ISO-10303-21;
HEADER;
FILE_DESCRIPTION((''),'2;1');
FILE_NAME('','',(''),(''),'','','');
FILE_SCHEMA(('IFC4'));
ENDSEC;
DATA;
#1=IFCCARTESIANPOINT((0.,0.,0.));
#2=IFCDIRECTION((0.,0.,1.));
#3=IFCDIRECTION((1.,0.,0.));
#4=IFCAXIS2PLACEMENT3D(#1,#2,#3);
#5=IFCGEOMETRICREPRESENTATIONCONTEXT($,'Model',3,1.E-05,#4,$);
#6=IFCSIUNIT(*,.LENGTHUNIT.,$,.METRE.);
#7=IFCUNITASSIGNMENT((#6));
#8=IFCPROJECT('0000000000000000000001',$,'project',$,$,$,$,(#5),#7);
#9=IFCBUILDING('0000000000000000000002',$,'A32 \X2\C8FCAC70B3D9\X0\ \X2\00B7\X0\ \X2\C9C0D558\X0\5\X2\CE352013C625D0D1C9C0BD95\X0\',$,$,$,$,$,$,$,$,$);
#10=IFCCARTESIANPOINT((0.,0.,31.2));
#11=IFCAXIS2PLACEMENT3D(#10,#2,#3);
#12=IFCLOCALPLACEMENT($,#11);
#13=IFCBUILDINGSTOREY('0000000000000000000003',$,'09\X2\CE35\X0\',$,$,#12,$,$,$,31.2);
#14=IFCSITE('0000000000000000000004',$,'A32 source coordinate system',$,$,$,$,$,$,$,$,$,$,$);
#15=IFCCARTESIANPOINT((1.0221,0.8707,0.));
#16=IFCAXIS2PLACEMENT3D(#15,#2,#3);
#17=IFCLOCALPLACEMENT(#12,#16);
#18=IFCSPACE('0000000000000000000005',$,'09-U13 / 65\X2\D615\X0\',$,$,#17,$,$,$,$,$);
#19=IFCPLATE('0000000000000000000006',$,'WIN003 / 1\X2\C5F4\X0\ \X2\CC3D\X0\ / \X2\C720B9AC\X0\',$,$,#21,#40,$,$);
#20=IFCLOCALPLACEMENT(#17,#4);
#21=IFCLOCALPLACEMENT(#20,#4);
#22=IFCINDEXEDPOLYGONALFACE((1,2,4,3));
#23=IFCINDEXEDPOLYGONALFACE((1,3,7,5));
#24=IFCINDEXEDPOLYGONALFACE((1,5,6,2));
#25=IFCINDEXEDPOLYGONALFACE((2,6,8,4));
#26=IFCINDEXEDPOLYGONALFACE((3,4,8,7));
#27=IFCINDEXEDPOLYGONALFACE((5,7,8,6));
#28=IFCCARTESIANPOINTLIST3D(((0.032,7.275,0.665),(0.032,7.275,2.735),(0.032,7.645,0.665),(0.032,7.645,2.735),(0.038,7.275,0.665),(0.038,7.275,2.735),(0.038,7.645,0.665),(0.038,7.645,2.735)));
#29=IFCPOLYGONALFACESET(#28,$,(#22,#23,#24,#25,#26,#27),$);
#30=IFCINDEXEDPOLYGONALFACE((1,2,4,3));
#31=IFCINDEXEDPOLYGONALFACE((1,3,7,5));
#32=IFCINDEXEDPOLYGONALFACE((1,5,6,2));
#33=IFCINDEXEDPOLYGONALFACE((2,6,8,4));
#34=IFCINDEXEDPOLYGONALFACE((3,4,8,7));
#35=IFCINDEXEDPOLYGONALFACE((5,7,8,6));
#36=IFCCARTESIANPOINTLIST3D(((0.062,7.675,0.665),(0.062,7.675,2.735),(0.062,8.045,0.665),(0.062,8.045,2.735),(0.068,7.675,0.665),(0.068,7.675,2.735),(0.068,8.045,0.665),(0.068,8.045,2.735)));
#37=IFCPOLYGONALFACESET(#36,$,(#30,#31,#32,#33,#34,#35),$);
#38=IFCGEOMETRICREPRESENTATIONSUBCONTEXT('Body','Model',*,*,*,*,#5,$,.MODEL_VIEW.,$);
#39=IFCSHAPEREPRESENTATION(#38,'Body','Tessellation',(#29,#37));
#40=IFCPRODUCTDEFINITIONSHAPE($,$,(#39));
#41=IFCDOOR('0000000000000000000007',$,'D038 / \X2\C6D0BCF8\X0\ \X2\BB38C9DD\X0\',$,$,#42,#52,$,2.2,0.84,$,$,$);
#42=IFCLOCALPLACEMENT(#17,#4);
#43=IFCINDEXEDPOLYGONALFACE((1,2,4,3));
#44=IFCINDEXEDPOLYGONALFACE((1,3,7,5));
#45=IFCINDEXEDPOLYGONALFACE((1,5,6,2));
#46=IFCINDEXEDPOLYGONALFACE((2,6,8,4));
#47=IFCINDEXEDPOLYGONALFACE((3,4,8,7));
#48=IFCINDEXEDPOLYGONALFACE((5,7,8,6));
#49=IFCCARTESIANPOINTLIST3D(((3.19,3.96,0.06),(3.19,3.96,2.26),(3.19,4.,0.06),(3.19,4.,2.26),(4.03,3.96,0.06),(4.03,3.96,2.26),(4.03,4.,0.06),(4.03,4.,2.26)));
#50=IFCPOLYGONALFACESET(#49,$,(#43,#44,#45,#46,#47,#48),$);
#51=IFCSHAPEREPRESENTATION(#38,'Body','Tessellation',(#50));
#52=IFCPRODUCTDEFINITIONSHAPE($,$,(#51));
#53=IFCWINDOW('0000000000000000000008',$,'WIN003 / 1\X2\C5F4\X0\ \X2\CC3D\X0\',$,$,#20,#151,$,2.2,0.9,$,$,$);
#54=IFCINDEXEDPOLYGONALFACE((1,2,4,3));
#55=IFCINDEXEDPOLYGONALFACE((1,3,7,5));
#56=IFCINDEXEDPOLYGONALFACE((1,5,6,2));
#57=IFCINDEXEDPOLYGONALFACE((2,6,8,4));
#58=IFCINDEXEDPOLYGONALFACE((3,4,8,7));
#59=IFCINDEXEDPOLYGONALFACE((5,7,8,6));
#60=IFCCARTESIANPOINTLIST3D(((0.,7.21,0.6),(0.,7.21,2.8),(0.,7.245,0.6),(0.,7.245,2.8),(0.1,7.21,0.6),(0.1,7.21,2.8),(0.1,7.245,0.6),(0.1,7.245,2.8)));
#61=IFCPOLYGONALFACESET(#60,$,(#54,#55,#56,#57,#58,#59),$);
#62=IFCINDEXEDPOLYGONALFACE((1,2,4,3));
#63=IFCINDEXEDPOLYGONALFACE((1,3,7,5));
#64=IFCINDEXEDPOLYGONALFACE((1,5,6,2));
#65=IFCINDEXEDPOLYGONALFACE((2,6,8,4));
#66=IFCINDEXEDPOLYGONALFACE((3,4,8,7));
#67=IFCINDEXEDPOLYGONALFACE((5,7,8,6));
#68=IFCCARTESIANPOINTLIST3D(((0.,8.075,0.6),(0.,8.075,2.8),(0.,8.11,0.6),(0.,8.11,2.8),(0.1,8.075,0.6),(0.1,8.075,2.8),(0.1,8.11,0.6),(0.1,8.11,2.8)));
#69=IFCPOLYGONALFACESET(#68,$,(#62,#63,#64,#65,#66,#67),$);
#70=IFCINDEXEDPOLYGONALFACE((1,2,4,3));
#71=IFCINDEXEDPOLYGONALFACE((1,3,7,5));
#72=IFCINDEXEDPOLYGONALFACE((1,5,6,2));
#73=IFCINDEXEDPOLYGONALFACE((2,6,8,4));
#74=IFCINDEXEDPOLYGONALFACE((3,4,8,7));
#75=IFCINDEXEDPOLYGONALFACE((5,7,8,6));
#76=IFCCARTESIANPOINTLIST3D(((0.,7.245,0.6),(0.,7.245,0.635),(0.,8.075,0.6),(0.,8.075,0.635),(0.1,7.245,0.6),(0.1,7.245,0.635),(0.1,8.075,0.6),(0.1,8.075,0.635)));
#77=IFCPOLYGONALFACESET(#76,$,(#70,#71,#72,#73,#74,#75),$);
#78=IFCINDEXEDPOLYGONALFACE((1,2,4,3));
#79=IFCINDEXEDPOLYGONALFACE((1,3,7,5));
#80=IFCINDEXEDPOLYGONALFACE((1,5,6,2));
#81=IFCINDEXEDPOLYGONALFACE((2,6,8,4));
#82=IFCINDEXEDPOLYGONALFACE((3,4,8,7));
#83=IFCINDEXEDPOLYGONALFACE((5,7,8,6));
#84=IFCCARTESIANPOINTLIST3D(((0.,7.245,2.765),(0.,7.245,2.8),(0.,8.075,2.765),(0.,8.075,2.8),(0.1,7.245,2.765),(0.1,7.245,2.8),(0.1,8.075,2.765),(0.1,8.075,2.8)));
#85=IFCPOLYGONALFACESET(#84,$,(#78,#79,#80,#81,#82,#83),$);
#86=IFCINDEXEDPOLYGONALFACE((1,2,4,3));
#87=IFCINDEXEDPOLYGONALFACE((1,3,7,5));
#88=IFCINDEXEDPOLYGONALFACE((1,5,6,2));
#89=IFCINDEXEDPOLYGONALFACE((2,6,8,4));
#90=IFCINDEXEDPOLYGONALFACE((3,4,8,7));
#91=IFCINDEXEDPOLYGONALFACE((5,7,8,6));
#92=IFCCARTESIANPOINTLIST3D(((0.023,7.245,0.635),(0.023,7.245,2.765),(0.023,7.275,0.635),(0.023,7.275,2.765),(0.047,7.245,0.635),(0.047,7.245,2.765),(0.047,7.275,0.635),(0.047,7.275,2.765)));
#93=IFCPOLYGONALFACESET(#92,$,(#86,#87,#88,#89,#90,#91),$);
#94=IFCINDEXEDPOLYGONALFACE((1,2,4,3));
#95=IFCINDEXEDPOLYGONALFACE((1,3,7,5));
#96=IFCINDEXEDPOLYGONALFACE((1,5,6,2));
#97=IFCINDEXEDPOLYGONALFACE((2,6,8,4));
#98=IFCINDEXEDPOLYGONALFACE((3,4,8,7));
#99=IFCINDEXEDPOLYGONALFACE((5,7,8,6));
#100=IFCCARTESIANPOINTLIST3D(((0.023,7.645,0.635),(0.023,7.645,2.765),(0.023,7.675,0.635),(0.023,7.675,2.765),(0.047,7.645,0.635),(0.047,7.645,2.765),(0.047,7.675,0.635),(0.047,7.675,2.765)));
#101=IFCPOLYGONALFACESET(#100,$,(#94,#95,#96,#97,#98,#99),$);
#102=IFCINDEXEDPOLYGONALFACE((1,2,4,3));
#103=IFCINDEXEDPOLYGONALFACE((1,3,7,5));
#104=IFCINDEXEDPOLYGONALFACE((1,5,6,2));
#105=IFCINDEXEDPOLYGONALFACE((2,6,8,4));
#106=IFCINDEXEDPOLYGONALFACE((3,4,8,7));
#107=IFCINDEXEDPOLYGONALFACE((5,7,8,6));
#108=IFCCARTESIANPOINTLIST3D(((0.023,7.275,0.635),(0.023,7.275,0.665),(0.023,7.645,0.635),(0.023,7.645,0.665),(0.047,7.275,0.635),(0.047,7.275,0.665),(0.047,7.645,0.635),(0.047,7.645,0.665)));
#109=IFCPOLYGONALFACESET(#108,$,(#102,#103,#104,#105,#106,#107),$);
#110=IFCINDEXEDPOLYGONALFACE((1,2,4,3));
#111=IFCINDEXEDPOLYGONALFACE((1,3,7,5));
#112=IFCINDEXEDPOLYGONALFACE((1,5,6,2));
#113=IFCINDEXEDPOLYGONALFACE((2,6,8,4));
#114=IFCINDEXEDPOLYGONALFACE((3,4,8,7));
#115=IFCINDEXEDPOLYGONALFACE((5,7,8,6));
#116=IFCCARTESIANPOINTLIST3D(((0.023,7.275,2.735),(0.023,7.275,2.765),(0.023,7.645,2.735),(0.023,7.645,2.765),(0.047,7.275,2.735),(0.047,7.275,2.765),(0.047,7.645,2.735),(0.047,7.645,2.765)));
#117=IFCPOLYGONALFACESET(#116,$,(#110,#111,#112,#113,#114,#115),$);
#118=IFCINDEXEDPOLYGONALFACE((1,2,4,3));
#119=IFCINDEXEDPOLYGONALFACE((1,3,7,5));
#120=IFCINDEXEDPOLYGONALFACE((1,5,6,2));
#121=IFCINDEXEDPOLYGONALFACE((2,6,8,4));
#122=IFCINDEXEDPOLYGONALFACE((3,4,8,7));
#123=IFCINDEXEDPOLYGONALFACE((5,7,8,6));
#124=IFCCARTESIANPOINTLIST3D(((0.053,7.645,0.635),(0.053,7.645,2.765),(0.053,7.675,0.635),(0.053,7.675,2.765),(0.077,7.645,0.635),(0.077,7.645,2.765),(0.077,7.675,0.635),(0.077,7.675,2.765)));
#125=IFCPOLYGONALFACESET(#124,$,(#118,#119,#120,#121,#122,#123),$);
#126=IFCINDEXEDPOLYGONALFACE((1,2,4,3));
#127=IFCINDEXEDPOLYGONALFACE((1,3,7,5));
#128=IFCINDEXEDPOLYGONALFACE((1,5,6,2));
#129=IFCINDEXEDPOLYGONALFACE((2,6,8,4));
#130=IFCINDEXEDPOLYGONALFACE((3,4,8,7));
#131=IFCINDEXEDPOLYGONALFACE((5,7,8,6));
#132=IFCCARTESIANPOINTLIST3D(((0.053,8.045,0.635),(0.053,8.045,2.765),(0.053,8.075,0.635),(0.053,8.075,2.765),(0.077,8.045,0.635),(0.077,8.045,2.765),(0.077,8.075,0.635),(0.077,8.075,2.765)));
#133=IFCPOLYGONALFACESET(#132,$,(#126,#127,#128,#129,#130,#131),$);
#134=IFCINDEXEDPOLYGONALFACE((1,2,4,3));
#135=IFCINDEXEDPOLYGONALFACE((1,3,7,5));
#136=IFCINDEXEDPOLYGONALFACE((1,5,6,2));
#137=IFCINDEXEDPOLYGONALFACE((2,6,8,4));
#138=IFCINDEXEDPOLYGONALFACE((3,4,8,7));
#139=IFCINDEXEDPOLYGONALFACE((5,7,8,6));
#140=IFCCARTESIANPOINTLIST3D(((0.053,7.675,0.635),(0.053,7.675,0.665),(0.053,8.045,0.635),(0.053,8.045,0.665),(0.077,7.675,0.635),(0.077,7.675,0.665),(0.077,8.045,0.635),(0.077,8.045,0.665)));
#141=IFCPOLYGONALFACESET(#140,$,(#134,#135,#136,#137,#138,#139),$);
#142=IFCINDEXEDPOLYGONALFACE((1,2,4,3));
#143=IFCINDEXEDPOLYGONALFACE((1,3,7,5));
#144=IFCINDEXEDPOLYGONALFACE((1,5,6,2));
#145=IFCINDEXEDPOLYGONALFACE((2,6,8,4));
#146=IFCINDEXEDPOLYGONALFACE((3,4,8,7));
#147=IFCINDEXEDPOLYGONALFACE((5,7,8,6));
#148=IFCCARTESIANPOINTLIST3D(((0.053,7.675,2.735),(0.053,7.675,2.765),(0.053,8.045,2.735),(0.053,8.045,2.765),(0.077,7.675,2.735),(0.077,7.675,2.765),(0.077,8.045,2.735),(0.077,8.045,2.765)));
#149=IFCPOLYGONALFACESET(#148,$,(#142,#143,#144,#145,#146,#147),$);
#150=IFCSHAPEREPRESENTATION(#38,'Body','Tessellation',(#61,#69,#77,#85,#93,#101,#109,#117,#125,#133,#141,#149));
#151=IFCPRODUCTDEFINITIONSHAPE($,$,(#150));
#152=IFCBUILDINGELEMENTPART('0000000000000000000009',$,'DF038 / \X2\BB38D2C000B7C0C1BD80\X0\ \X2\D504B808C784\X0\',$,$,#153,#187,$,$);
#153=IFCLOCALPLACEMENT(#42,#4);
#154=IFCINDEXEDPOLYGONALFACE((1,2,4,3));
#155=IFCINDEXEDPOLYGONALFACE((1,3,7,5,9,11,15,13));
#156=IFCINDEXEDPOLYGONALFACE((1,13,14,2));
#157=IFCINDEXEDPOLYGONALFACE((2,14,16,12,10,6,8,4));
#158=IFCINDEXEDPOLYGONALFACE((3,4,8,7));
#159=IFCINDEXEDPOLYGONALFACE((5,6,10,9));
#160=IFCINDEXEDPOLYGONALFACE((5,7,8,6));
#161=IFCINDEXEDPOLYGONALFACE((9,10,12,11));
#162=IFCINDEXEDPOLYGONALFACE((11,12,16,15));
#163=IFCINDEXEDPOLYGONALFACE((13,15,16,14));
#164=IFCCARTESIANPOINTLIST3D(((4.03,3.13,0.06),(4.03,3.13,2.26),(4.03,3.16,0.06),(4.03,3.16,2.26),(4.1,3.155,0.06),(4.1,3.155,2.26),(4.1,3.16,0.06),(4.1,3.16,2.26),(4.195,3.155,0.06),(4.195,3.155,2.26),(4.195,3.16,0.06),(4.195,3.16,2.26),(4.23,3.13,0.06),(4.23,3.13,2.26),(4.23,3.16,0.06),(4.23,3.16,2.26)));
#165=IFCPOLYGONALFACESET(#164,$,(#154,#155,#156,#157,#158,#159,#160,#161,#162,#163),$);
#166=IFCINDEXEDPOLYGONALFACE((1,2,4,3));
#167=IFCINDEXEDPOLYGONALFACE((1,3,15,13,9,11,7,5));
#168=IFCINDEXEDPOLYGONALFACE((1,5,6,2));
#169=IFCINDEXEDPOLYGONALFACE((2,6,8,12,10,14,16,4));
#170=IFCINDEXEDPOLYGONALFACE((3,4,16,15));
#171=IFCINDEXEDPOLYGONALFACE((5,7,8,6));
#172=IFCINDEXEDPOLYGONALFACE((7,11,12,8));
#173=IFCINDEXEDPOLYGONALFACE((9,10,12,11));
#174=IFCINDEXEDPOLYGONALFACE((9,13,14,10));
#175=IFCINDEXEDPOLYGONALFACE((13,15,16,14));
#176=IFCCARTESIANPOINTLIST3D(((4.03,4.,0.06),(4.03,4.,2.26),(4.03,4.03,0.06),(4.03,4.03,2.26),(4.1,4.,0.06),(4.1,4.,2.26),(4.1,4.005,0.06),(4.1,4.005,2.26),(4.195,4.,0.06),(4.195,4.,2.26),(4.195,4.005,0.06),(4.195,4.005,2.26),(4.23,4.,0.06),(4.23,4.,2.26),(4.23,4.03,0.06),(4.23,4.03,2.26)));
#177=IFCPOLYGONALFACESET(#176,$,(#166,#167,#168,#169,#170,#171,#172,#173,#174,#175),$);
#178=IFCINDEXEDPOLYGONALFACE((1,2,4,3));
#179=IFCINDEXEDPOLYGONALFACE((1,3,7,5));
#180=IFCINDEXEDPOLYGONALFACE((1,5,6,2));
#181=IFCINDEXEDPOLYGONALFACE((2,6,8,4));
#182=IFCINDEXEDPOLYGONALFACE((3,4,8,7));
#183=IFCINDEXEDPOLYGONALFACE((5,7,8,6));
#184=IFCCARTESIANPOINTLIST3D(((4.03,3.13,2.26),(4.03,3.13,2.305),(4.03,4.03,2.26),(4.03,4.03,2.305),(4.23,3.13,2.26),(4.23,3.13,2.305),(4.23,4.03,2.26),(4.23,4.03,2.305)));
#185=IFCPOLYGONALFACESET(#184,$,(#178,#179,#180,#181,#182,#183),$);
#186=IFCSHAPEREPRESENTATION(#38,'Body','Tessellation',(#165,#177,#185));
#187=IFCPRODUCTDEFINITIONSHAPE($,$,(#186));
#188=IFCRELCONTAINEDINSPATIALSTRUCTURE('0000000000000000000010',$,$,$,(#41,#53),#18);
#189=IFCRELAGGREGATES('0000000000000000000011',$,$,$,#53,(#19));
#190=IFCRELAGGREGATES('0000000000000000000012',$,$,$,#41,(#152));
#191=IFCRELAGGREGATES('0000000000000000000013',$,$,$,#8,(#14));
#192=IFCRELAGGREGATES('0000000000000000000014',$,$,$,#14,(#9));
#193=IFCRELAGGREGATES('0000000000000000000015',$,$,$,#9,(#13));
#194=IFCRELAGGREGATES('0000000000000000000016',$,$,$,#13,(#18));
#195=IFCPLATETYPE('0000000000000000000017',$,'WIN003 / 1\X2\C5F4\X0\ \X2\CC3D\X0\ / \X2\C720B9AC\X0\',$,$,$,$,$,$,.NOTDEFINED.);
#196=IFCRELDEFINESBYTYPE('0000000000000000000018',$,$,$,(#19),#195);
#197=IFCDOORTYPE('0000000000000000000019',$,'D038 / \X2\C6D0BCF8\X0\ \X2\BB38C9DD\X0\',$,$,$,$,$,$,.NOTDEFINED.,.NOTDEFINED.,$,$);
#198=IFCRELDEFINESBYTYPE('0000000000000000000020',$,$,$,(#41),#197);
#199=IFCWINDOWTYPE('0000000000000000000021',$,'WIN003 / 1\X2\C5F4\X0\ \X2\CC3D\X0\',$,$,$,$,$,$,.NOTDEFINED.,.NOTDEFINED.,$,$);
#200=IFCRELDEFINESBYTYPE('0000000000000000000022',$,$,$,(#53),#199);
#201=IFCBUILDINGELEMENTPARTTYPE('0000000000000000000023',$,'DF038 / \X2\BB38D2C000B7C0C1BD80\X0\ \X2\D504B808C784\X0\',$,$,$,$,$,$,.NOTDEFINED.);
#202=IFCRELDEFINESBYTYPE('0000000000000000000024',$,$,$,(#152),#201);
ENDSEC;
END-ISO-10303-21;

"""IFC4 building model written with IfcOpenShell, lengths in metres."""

from ifc_helpers import new_model, si_unit, frame, origin, origin_with_axes, place, context, subcontext, project, spatial, polyline, outline, extrude, source, transform, mapped, type_object, type_shapes, element, aggregate, save


model = new_model("IFC4")

# Units and contexts
model_context = context("Model", 3, precision=1e-05, world=origin_with_axes())
body_context = subcontext(model_context, "Body", "Model", "MODEL_VIEW")
ifc_project = project(units=[si_unit("LENGTHUNIT", "METRE")], contexts=[model_context])

# Plate
storey_placement = place(None, frame((0.0, 0.0, 31.2), z_axis=(0.0, 0.0, 1.0), x_axis=(1.0, 0.0, 0.0)))
space_placement = place(storey_placement, frame((1.0221, 0.8707, 0.0), z_axis=(0.0, 0.0, 1.0), x_axis=(1.0, 0.0, 0.0)))
plate_type_1 = type_object("IfcPlateType", Name="WIN003 / 1열 창 / 유리", PredefinedType="NOTDEFINED")
shared_shape_1 = source(origin(), body_context, "Body", "SweptSolid", [
    extrude(outline(polyline([(0.032, 7.275), (0.032, 7.645), (0.038, 7.645), (0.038, 7.275), (0.032, 7.275)])), frame((0.0, 0.0, 0.665)), (0.0, 0.0, 1.0), 2.07),
    extrude(outline(polyline([(0.062, 7.675), (0.062, 8.045), (0.068, 8.045), (0.068, 7.675), (0.062, 7.675)])), frame((0.0, 0.0, 0.665)), (0.0, 0.0, 1.0), 2.07),
])
type_shapes(plate_type_1, [shared_shape_1])
window_1_placement = place(space_placement, origin_with_axes())
plate_1_placement = place(window_1_placement, origin_with_axes())
plate_1 = element("IfcPlate", 1, at=plate_1_placement, type_object=plate_type_1, Name="WIN003 / 1열 창 / 유리", context=body_context, shape_type="MappedRepresentation", body=[
    mapped(shared_shape_1, transform((0.0, 0.0, 0.0), scale=1.0)),
])

# Site, building, storey, space
site = spatial("IfcSite", under=ifc_project, Name="A32 source coordinate system")
building = spatial("IfcBuilding", under=site, Name="A32 주거동 · 지하5층–옥탑지붕")
storey = spatial("IfcBuildingStorey", under=building, at=storey_placement, Name="09층", Elevation=31.2)
space = spatial("IfcSpace", under=storey, at=space_placement, Name="09-U13 / 65형")

# Door
door_type_1 = type_object("IfcDoorType", Name="D038 / 원본 문짝", OperationType="NOTDEFINED", PredefinedType="NOTDEFINED")
shared_shape_2 = source(origin(), body_context, "Body", "SweptSolid", [
    extrude(outline(polyline([(3.19, 3.96), (3.19, 4.0), (4.03, 4.0), (4.03, 3.96), (3.19, 3.96)])), frame((0.0, 0.0, 0.06)), (0.0, 0.0, 1.0), 2.2),
])
type_shapes(door_type_1, [shared_shape_2])
door_1_placement = place(space_placement, origin_with_axes())
door_1 = element("IfcDoor", 2, at=door_1_placement, inside=space, type_object=door_type_1, Name="D038 / 원본 문짝", OverallHeight=2.2, OverallWidth=0.84, context=body_context, shape_type="MappedRepresentation", body=[
    mapped(shared_shape_2, transform((0.0, 0.0, 0.0), scale=1.0)),
])

# Window
window_type_1 = type_object("IfcWindowType", Name="WIN003 / 1열 창", PartitioningType="NOTDEFINED", PredefinedType="NOTDEFINED")
shared_shape_3 = source(origin(), body_context, "Body", "SweptSolid", [
    extrude(outline(polyline([(0.0, 7.21), (0.0, 7.245), (0.1, 7.245), (0.1, 7.21), (0.0, 7.21)])), frame((0.0, 0.0, 0.6)), (0.0, 0.0, 1.0), 2.2),
    extrude(outline(polyline([(0.0, 8.075), (0.0, 8.11), (0.1, 8.11), (0.1, 8.075), (0.0, 8.075)])), frame((0.0, 0.0, 0.6)), (0.0, 0.0, 1.0), 2.2),
    extrude(outline(polyline([(0.0, 7.245), (0.0, 8.075), (0.1, 8.075), (0.1, 7.245), (0.0, 7.245)])), frame((0.0, 0.0, 0.6)), (0.0, 0.0, 1.0), 0.035),
    extrude(outline(polyline([(0.0, 7.245), (0.0, 8.075), (0.1, 8.075), (0.1, 7.245), (0.0, 7.245)])), frame((0.0, 0.0, 2.765)), (0.0, 0.0, 1.0), 0.035),
    extrude(outline(polyline([(0.023, 7.245), (0.023, 7.275), (0.047, 7.275), (0.047, 7.245), (0.023, 7.245)])), frame((0.0, 0.0, 0.635)), (0.0, 0.0, 1.0), 2.13),
    extrude(outline(polyline([(0.023, 7.645), (0.023, 7.675), (0.047, 7.675), (0.047, 7.645), (0.023, 7.645)])), frame((0.0, 0.0, 0.635)), (0.0, 0.0, 1.0), 2.13),
    extrude(outline(polyline([(0.023, 7.275), (0.023, 7.645), (0.047, 7.645), (0.047, 7.275), (0.023, 7.275)])), frame((0.0, 0.0, 0.635)), (0.0, 0.0, 1.0), 0.03),
    extrude(outline(polyline([(0.023, 7.275), (0.023, 7.645), (0.047, 7.645), (0.047, 7.275), (0.023, 7.275)])), frame((0.0, 0.0, 2.735)), (0.0, 0.0, 1.0), 0.03),
    extrude(outline(polyline([(0.053, 7.645), (0.053, 7.675), (0.077, 7.675), (0.077, 7.645), (0.053, 7.645)])), frame((0.0, 0.0, 0.635)), (0.0, 0.0, 1.0), 2.13),
    extrude(outline(polyline([(0.053, 8.045), (0.053, 8.075), (0.077, 8.075), (0.077, 8.045), (0.053, 8.045)])), frame((0.0, 0.0, 0.635)), (0.0, 0.0, 1.0), 2.13),
    extrude(outline(polyline([(0.053, 7.675), (0.053, 8.045), (0.077, 8.045), (0.077, 7.675), (0.053, 7.675)])), frame((0.0, 0.0, 0.635)), (0.0, 0.0, 1.0), 0.03),
    extrude(outline(polyline([(0.053, 7.675), (0.053, 8.045), (0.077, 8.045), (0.077, 7.675), (0.053, 7.675)])), frame((0.0, 0.0, 2.735)), (0.0, 0.0, 1.0), 0.03),
])
type_shapes(window_type_1, [shared_shape_3])
window_1 = element("IfcWindow", 3, at=window_1_placement, inside=space, type_object=window_type_1, Name="WIN003 / 1열 창", OverallHeight=2.2, OverallWidth=0.9, context=body_context, shape_type="MappedRepresentation", body=[
    mapped(shared_shape_3, transform((0.0, 0.0, 0.0), scale=1.0)),
])
aggregate(window_1, [plate_1])

# Building element part
building_element_part_type_1 = type_object("IfcBuildingElementPartType", Name="DF038 / 문틀·상부 프레임", PredefinedType="NOTDEFINED")
shared_shape_4 = source(origin(), body_context, "Body", "SweptSolid", [
    extrude(outline(polyline([(4.03, 3.16), (4.1, 3.16), (4.1, 3.155), (4.195, 3.155), (4.195, 3.16), (4.23, 3.16), (4.23, 3.13), (4.03, 3.13), (4.03, 3.16)])), frame((0.0, 0.0, 0.06)), (0.0, 0.0, 1.0), 2.2),
    extrude(outline(polyline([(4.23, 4.03), (4.23, 4.0), (4.195, 4.0), (4.195, 4.005), (4.1, 4.005), (4.1, 4.0), (4.03, 4.0), (4.03, 4.03), (4.23, 4.03)])), frame((0.0, 0.0, 0.06)), (0.0, 0.0, 1.0), 2.2),
    extrude(outline(polyline([(4.03, 3.13), (4.03, 4.03), (4.23, 4.03), (4.23, 3.13), (4.03, 3.13)])), frame((0.0, 0.0, 2.26)), (0.0, 0.0, 1.0), 0.045),
])
type_shapes(building_element_part_type_1, [shared_shape_4])
building_element_part_1_placement = place(door_1_placement, origin_with_axes())
building_element_part_1 = element("IfcBuildingElementPart", 4, at=building_element_part_1_placement, type_object=building_element_part_type_1, Name="DF038 / 문틀·상부 프레임", context=body_context, shape_type="MappedRepresentation", body=[
    mapped(shared_shape_4, transform((0.0, 0.0, 0.0), scale=1.0)),
])
aggregate(door_1, [building_element_part_1])

save(model, "model.ifc")
